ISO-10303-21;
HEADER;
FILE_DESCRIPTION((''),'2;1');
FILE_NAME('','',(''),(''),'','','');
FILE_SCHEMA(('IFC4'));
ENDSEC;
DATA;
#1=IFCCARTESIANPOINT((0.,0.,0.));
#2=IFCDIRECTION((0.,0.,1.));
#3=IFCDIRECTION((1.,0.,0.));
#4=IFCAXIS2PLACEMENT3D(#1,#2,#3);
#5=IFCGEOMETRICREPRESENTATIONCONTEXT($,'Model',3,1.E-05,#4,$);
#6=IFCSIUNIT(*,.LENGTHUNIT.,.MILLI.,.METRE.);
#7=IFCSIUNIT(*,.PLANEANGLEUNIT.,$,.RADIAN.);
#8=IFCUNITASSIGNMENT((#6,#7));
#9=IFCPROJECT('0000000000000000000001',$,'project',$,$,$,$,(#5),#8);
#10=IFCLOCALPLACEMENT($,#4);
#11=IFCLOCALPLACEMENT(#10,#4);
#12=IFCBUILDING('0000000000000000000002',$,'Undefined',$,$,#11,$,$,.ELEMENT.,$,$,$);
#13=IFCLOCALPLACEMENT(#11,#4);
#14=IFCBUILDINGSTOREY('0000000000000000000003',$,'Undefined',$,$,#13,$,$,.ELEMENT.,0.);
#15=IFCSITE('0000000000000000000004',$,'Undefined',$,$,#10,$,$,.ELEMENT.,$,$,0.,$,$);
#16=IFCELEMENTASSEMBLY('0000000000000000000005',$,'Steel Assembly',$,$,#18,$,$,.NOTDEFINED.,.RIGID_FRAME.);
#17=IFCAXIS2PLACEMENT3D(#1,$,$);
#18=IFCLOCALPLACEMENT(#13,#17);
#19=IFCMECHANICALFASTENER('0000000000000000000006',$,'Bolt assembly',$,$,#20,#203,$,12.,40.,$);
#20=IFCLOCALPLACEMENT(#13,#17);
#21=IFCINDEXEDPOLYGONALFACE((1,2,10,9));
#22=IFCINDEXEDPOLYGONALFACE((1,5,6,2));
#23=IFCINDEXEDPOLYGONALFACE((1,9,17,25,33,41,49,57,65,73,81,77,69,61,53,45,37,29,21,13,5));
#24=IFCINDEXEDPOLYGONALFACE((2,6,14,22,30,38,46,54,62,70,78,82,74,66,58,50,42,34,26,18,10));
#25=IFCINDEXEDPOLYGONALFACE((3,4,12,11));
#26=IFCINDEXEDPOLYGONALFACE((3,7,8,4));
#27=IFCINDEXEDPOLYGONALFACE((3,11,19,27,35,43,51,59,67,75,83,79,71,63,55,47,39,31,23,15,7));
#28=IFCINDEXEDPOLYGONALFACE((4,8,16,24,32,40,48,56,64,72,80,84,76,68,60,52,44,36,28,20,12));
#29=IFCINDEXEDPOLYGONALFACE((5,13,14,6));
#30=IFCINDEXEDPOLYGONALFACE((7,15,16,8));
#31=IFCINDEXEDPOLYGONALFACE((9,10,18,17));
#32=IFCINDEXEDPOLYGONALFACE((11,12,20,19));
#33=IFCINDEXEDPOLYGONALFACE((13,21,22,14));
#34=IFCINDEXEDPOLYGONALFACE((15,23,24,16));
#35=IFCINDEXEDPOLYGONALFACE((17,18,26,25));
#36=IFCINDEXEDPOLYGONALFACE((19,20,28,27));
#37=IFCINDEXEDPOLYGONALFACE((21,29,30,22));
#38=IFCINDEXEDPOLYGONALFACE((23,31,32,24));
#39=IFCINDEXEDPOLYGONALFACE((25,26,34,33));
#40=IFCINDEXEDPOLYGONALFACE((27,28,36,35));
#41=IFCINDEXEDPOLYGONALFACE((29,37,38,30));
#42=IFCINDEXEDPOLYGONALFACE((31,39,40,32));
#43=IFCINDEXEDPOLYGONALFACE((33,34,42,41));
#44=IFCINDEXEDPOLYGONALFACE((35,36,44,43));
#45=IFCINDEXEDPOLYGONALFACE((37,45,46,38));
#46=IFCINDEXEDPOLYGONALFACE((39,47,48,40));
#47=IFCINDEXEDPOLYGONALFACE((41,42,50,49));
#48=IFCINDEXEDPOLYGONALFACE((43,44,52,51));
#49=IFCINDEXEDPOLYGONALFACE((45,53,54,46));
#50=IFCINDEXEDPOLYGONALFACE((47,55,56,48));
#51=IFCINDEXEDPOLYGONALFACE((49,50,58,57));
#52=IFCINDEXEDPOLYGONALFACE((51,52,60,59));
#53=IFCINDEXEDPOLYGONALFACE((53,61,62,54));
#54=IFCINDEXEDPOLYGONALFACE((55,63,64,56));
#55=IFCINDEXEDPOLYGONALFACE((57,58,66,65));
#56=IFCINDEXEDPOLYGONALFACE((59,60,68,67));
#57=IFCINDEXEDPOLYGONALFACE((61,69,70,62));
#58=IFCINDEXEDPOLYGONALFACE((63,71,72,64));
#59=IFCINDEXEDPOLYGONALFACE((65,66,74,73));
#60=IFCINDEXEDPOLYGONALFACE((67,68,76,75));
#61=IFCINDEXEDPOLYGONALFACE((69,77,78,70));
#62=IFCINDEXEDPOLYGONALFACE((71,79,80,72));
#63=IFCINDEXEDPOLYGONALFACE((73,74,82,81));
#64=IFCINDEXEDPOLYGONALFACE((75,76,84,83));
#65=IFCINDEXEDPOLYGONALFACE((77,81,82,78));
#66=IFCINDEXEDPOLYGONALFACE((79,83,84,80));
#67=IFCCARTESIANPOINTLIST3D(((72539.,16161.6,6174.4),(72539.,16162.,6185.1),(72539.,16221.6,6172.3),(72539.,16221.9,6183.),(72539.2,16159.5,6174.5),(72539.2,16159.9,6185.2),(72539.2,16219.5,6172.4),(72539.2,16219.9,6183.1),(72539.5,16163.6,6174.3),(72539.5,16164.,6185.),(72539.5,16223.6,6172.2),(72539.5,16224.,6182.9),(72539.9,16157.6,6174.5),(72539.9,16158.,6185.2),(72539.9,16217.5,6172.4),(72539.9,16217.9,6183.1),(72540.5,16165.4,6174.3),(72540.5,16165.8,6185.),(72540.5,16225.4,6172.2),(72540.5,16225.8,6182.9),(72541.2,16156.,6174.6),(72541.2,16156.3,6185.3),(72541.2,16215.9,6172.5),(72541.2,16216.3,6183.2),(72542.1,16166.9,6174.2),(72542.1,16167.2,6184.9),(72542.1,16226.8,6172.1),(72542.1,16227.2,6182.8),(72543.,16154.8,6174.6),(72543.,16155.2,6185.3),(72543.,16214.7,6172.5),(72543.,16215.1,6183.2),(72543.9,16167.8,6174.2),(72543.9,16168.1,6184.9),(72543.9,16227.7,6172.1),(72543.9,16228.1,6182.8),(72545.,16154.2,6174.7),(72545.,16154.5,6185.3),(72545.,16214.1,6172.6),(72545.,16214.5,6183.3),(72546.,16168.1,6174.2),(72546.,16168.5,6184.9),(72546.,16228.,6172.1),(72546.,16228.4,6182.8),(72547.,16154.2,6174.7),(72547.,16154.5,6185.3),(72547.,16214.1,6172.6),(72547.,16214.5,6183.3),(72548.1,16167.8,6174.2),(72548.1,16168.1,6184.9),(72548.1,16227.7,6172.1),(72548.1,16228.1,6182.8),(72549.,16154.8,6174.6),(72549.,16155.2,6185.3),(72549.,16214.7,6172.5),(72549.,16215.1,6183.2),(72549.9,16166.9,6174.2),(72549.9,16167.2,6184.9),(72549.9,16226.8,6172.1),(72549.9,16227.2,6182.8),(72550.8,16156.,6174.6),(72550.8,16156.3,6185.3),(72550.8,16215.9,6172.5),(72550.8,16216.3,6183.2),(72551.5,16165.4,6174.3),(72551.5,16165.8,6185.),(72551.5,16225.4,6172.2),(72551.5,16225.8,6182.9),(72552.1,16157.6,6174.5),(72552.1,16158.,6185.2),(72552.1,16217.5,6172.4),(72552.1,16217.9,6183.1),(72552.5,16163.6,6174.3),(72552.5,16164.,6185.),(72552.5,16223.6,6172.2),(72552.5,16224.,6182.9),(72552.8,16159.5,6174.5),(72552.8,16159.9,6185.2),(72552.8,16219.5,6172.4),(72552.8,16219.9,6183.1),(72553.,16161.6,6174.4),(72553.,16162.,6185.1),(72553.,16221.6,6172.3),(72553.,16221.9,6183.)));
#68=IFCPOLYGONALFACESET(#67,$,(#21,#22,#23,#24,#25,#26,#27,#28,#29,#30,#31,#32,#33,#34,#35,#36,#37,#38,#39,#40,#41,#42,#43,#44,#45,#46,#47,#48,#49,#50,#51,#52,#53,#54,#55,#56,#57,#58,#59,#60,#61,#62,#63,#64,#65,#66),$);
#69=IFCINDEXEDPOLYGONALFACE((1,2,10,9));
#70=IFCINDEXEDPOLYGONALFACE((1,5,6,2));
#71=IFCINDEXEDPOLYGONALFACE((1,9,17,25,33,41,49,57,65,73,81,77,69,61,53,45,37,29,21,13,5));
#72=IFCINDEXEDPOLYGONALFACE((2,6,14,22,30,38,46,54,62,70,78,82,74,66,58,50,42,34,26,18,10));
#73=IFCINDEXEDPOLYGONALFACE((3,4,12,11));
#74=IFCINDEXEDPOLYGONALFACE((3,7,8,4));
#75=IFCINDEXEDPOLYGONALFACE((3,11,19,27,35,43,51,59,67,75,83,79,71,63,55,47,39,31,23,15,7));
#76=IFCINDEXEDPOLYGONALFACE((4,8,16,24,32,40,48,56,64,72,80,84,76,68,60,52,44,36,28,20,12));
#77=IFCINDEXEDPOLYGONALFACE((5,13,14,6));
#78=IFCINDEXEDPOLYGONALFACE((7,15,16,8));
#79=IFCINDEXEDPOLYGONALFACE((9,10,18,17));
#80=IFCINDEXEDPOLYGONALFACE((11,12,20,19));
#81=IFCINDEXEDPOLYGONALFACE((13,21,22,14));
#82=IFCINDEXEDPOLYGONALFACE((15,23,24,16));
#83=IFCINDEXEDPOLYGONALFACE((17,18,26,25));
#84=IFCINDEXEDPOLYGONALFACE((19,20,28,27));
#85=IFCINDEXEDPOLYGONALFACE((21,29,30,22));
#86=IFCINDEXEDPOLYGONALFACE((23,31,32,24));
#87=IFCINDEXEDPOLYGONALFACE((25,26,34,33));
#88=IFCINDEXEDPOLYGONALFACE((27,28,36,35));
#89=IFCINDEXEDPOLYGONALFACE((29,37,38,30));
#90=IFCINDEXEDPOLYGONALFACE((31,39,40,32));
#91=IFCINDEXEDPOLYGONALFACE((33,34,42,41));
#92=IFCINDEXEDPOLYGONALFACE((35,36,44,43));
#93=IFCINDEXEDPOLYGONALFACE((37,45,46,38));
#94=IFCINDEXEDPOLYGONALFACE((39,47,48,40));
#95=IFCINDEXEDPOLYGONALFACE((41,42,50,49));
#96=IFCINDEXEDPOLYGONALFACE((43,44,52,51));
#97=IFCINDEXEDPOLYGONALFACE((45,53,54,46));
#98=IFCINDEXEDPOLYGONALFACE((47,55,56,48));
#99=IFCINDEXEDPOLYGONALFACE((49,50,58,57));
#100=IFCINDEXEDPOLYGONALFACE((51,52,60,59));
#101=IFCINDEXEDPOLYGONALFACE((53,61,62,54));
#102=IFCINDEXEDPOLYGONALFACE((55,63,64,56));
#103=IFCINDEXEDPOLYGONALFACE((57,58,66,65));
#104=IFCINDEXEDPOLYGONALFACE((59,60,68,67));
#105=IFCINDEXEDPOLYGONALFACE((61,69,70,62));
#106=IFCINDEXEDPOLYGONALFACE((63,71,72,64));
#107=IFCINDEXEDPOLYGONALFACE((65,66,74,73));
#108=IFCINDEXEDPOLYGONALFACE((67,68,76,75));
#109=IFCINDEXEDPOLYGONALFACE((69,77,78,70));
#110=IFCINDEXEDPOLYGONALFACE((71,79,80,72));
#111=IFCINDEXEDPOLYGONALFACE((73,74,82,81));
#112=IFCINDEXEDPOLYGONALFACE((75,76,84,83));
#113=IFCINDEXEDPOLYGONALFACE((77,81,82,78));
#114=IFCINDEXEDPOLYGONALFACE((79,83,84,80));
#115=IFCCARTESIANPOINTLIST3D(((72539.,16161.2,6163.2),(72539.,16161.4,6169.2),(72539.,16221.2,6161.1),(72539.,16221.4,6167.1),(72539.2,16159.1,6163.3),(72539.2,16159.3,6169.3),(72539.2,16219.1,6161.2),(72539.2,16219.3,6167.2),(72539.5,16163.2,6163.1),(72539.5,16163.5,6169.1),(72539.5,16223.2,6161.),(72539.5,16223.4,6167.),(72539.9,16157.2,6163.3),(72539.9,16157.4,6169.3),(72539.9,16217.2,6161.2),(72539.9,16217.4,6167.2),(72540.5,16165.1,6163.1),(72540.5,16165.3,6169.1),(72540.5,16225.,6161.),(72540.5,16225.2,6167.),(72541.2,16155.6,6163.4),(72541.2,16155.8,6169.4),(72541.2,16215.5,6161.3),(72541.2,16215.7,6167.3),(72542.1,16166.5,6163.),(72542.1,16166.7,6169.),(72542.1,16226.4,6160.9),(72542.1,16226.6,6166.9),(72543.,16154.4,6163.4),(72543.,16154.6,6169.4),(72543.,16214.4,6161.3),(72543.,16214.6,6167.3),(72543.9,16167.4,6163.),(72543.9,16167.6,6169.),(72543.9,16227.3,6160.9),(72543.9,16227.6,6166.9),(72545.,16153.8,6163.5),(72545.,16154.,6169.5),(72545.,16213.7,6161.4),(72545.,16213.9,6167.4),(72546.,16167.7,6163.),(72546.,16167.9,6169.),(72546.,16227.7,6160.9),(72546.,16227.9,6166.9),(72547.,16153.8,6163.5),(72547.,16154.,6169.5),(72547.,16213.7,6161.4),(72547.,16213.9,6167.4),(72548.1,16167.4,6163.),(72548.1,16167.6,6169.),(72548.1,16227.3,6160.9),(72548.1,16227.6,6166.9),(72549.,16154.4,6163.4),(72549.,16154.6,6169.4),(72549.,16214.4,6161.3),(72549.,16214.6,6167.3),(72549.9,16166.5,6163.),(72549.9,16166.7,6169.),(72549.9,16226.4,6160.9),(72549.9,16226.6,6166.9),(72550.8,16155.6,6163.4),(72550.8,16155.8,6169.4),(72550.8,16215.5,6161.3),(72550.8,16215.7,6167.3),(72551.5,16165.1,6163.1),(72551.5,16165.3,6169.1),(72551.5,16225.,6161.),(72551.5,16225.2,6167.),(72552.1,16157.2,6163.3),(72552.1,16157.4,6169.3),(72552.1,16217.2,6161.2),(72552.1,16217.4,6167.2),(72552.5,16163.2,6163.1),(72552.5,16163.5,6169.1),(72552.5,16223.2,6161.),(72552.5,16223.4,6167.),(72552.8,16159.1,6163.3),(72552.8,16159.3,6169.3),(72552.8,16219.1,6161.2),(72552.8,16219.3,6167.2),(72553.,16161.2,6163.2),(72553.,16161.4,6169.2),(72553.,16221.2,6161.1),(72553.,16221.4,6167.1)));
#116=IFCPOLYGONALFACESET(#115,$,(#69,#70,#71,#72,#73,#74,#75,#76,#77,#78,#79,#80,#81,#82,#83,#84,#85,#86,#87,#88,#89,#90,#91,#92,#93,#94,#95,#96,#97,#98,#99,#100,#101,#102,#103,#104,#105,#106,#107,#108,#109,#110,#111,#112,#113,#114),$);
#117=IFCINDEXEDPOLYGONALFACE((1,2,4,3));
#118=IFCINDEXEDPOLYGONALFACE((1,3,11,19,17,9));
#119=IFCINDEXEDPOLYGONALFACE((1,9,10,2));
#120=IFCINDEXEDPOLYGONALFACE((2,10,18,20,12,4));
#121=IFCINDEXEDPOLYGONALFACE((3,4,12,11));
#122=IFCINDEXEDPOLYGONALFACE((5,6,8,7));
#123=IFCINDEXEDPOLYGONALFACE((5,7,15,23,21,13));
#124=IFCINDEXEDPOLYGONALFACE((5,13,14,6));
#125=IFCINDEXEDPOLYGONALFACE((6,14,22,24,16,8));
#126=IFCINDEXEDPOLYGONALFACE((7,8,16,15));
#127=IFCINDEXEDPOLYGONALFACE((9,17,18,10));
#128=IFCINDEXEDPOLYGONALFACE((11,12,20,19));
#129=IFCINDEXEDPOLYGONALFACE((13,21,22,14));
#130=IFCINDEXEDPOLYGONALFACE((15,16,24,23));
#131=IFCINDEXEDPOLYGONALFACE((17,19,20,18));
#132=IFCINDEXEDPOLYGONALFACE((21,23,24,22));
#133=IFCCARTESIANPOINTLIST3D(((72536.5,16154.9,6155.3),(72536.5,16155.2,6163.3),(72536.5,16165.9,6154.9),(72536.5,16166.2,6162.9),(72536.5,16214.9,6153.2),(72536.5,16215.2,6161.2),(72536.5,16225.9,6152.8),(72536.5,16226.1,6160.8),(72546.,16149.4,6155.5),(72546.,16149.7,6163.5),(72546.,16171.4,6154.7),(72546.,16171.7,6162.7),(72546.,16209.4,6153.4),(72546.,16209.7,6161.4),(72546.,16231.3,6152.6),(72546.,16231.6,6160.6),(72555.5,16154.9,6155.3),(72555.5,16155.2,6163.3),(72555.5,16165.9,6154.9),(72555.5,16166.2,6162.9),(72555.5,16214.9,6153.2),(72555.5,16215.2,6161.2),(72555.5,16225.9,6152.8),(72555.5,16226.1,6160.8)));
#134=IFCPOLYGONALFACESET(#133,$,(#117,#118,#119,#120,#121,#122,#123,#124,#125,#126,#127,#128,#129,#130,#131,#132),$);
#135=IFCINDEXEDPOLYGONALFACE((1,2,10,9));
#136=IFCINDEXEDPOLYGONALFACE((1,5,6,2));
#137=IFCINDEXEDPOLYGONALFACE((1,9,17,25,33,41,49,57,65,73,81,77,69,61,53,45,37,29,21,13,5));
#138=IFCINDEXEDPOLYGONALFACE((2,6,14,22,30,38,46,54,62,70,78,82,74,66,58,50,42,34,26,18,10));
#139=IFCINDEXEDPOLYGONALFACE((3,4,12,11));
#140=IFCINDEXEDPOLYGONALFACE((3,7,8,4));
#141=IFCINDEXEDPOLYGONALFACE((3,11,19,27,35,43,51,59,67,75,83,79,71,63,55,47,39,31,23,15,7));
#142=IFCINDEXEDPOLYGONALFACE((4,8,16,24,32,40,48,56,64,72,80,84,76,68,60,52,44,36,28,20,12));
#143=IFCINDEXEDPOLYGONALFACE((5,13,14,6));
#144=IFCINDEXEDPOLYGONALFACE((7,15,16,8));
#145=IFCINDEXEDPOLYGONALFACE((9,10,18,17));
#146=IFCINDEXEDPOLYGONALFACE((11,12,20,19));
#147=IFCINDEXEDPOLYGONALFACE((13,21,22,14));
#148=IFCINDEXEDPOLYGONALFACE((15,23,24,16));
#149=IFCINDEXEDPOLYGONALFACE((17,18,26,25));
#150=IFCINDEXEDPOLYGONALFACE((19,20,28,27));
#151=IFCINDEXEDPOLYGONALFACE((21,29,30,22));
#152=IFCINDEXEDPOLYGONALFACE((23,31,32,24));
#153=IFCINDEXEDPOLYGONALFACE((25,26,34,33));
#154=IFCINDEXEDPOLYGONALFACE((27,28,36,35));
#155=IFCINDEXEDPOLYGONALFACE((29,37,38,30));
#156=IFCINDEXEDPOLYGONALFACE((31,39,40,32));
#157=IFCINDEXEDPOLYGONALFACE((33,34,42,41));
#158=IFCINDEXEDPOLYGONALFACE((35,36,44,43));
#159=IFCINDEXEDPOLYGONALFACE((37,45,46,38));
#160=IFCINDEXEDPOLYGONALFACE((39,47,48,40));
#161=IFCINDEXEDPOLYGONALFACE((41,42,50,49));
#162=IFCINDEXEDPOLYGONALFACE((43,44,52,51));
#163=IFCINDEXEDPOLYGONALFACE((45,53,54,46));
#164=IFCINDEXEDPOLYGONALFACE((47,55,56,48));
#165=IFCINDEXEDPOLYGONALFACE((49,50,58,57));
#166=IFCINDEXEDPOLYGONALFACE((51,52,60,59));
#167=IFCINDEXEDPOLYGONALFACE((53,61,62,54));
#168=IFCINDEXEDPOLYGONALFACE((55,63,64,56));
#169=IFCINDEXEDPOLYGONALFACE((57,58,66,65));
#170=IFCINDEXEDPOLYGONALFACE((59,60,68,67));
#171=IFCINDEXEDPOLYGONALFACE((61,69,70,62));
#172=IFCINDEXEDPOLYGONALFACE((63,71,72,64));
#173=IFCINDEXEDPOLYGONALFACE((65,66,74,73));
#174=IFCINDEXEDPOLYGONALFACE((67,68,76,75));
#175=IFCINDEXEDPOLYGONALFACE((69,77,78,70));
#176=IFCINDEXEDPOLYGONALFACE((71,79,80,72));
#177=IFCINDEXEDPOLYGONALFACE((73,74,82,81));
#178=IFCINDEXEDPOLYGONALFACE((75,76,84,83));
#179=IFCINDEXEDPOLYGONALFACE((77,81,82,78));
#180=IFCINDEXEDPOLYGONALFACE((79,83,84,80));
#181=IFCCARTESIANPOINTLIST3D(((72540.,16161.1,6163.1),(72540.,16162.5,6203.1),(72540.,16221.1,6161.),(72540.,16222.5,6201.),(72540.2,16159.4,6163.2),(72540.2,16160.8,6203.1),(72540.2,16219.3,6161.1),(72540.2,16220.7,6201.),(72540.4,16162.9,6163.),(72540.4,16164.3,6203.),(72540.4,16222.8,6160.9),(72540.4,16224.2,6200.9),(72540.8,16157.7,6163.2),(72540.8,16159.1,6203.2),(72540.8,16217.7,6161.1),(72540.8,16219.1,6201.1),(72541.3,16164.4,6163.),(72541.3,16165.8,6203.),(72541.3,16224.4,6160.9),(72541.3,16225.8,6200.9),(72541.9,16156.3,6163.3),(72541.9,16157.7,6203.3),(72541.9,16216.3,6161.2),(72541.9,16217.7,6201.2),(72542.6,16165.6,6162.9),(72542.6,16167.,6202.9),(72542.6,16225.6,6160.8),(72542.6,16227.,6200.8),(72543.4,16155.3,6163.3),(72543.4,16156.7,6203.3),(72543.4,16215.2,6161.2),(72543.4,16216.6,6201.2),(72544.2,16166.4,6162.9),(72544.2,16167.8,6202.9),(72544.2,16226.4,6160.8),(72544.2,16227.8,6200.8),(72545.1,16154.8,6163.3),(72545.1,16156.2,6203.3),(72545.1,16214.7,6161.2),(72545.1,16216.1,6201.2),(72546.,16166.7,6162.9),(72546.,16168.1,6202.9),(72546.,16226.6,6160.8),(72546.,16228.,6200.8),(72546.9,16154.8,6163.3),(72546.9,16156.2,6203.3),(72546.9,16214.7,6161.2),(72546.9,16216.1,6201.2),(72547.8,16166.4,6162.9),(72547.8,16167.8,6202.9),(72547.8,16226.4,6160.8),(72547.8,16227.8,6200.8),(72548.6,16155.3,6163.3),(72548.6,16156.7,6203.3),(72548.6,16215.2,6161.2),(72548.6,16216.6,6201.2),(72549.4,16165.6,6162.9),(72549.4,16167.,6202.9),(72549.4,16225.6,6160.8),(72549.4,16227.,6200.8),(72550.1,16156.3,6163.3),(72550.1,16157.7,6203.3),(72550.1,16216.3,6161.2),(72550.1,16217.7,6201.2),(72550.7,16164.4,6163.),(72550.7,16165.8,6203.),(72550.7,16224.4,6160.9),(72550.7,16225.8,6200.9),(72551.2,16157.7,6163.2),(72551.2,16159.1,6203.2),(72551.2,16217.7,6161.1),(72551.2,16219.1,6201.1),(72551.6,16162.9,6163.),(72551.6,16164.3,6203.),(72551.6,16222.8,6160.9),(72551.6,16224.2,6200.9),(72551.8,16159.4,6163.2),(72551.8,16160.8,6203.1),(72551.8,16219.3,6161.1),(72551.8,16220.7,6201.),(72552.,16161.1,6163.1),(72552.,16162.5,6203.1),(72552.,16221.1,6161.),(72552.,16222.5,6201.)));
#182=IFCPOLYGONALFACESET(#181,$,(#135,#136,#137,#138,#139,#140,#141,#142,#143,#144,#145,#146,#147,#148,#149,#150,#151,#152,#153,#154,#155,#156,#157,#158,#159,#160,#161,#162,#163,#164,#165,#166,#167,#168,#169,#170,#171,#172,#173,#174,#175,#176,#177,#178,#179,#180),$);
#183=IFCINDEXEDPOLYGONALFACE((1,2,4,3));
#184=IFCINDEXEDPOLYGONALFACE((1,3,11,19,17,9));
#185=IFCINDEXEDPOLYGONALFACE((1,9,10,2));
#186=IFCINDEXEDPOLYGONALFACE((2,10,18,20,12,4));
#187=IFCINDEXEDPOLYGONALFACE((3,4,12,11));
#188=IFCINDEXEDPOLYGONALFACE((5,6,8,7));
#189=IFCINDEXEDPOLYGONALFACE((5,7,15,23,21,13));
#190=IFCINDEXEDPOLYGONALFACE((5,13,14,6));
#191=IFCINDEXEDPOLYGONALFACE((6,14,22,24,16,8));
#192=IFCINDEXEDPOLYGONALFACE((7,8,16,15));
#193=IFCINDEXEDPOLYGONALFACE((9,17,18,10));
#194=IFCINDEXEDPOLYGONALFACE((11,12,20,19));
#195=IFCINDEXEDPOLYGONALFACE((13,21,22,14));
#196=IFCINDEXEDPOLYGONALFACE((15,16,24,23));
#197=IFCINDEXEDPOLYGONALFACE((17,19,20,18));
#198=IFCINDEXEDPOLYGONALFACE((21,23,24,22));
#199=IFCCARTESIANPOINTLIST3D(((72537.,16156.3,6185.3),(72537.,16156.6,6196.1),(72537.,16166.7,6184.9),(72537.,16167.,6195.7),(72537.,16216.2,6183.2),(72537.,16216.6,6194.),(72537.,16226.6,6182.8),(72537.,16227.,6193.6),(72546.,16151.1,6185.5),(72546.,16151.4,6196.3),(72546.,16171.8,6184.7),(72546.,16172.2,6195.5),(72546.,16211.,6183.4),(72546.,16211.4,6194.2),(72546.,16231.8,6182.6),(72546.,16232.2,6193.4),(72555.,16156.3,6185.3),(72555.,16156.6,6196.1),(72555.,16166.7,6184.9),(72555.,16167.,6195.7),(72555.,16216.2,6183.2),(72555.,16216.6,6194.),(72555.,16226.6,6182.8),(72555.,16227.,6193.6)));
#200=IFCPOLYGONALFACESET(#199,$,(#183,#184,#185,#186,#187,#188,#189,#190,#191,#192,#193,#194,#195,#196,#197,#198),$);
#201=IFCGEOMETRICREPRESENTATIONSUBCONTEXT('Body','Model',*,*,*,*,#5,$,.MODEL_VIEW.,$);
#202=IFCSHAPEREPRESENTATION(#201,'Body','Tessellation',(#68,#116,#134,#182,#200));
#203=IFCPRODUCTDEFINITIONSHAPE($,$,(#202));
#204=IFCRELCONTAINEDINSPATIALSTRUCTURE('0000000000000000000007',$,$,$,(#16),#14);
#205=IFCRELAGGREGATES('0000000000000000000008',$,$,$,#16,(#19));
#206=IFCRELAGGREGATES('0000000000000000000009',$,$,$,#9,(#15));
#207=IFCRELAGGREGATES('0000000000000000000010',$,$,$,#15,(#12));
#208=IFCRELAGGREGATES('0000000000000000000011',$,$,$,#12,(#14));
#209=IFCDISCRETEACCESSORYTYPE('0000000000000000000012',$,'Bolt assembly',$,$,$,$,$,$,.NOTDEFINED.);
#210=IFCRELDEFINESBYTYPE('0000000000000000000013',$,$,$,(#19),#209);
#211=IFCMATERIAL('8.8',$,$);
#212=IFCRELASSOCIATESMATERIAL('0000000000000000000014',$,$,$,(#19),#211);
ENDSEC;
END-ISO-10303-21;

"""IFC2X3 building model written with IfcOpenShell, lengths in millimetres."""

from ifc_helpers import new_model, si_unit, frame, origin_with_axes, origin_2d_with_axis, place, context, subcontext, project, spatial, polyline, circle, outline, extrude, source, transform, mapped, material, type_object, element, aggregate, save


model = new_model("IFC2X3")

# Units and contexts
model_context = context("Model", 3, precision=1e-05, world=origin_with_axes())
body_context = subcontext(model_context, "Body", "Model", "MODEL_VIEW")
ifc_project = project(units=[si_unit("LENGTHUNIT", "METRE", prefix="MILLI"), si_unit("PLANEANGLEUNIT", "RADIAN")], contexts=[model_context])

# Site, building, storey
site_placement = place(None, origin_with_axes())
site = spatial("IfcSite", under=ifc_project, at=site_placement, Name="Undefined", CompositionType="ELEMENT", RefElevation=0.0)
building_placement = place(site_placement, origin_with_axes())
building = spatial("IfcBuilding", under=site, at=building_placement, Name="Undefined", CompositionType="ELEMENT")
storey_placement = place(building_placement, origin_with_axes())
storey = spatial("IfcBuildingStorey", under=building, at=storey_placement, Name="Undefined", CompositionType="ELEMENT", Elevation=0.0)

# Element assembly
assembly_1_placement = place(storey_placement, origin_with_axes())
assembly_1 = element("IfcElementAssembly", 1, at=assembly_1_placement, inside=storey, Name="Steel Assembly", AssemblyPlace="NOTDEFINED", PredefinedType="RIGID_FRAME")

# Shared definitions
discrete_accessory_type_1 = type_object("IfcDiscreteAccessoryType", Name="Bolt assembly")
ifc_material_1 = material(Name="8.8")

# Mechanical fastener
shared_shape_1 = source(origin_with_axes(), body_context, "Body", "SweptSolid", [
    extrude(circle(Radius=7.0, at=origin_2d_with_axis()), frame((0.0, 8.3, 0.0), z_axis=(0.0, 1.0, 0.0), x_axis=(1.0, 0.0, 0.0)), (0.0, 0.0, 1.0), 10.7),
    extrude(circle(Radius=7.0, at=origin_2d_with_axis()), frame((0.0, -2.9, 0.0), z_axis=(0.0, 1.0, 0.0), x_axis=(1.0, 0.0, 0.0)), (0.0, 0.0, 1.0), 6.0),
    extrude(outline(polyline([(11.0, 0.0), (5.5, 9.5), (-5.5, 9.5), (-11.0, 0.0), (-5.5, -9.5), (5.5, -9.5), (11.0, 0.0)])), frame((0.0, -11.0, 0.0), z_axis=(0.0, 1.0, 0.0), x_axis=(1.0, 0.0, 0.0)), (0.0, 0.0, 1.0), 8.0),
    extrude(circle(Radius=6.0, at=origin_2d_with_axis()), frame((0.0, -3.0, 0.0), z_axis=(0.0, 1.0, 0.0), x_axis=(1.0, 0.0, 0.0)), (0.0, 0.0, 1.0), 40.0),
    extrude(outline(polyline([(10.4, 0.0), (5.2, 9.0), (-5.2, 9.0), (-10.4, 0.0), (-5.2, -9.0), (5.2, -9.0), (10.4, 0.0)])), frame((0.0, 19.0, 0.0), z_axis=(0.0, 1.0, 0.0), x_axis=(1.0, 0.0, 0.0)), (0.0, 0.0, 1.0), 10.8),
])
mechanical_fastener_1_placement = place(assembly_1_placement, frame((72546.0, 15901.0, 6175.2), z_axis=(1.0, 0.0, 0.0), x_axis=(0.0, 0.999388, -0.034978)))
mechanical_fastener_1 = element("IfcMechanicalFastener", 2, at=mechanical_fastener_1_placement, type_object=discrete_accessory_type_1, material=ifc_material_1, Name="Bolt assembly", NominalDiameter=12.0, NominalLength=40.0, context=body_context, shape_type="MappedRepresentation", body=[
    mapped(shared_shape_1, transform((260.0, 0.0, 0.0))),
    mapped(shared_shape_1, transform((320.0, 0.0, 0.0))),
])
aggregate(assembly_1, [mechanical_fastener_1])

save(model, "model.ifc")
